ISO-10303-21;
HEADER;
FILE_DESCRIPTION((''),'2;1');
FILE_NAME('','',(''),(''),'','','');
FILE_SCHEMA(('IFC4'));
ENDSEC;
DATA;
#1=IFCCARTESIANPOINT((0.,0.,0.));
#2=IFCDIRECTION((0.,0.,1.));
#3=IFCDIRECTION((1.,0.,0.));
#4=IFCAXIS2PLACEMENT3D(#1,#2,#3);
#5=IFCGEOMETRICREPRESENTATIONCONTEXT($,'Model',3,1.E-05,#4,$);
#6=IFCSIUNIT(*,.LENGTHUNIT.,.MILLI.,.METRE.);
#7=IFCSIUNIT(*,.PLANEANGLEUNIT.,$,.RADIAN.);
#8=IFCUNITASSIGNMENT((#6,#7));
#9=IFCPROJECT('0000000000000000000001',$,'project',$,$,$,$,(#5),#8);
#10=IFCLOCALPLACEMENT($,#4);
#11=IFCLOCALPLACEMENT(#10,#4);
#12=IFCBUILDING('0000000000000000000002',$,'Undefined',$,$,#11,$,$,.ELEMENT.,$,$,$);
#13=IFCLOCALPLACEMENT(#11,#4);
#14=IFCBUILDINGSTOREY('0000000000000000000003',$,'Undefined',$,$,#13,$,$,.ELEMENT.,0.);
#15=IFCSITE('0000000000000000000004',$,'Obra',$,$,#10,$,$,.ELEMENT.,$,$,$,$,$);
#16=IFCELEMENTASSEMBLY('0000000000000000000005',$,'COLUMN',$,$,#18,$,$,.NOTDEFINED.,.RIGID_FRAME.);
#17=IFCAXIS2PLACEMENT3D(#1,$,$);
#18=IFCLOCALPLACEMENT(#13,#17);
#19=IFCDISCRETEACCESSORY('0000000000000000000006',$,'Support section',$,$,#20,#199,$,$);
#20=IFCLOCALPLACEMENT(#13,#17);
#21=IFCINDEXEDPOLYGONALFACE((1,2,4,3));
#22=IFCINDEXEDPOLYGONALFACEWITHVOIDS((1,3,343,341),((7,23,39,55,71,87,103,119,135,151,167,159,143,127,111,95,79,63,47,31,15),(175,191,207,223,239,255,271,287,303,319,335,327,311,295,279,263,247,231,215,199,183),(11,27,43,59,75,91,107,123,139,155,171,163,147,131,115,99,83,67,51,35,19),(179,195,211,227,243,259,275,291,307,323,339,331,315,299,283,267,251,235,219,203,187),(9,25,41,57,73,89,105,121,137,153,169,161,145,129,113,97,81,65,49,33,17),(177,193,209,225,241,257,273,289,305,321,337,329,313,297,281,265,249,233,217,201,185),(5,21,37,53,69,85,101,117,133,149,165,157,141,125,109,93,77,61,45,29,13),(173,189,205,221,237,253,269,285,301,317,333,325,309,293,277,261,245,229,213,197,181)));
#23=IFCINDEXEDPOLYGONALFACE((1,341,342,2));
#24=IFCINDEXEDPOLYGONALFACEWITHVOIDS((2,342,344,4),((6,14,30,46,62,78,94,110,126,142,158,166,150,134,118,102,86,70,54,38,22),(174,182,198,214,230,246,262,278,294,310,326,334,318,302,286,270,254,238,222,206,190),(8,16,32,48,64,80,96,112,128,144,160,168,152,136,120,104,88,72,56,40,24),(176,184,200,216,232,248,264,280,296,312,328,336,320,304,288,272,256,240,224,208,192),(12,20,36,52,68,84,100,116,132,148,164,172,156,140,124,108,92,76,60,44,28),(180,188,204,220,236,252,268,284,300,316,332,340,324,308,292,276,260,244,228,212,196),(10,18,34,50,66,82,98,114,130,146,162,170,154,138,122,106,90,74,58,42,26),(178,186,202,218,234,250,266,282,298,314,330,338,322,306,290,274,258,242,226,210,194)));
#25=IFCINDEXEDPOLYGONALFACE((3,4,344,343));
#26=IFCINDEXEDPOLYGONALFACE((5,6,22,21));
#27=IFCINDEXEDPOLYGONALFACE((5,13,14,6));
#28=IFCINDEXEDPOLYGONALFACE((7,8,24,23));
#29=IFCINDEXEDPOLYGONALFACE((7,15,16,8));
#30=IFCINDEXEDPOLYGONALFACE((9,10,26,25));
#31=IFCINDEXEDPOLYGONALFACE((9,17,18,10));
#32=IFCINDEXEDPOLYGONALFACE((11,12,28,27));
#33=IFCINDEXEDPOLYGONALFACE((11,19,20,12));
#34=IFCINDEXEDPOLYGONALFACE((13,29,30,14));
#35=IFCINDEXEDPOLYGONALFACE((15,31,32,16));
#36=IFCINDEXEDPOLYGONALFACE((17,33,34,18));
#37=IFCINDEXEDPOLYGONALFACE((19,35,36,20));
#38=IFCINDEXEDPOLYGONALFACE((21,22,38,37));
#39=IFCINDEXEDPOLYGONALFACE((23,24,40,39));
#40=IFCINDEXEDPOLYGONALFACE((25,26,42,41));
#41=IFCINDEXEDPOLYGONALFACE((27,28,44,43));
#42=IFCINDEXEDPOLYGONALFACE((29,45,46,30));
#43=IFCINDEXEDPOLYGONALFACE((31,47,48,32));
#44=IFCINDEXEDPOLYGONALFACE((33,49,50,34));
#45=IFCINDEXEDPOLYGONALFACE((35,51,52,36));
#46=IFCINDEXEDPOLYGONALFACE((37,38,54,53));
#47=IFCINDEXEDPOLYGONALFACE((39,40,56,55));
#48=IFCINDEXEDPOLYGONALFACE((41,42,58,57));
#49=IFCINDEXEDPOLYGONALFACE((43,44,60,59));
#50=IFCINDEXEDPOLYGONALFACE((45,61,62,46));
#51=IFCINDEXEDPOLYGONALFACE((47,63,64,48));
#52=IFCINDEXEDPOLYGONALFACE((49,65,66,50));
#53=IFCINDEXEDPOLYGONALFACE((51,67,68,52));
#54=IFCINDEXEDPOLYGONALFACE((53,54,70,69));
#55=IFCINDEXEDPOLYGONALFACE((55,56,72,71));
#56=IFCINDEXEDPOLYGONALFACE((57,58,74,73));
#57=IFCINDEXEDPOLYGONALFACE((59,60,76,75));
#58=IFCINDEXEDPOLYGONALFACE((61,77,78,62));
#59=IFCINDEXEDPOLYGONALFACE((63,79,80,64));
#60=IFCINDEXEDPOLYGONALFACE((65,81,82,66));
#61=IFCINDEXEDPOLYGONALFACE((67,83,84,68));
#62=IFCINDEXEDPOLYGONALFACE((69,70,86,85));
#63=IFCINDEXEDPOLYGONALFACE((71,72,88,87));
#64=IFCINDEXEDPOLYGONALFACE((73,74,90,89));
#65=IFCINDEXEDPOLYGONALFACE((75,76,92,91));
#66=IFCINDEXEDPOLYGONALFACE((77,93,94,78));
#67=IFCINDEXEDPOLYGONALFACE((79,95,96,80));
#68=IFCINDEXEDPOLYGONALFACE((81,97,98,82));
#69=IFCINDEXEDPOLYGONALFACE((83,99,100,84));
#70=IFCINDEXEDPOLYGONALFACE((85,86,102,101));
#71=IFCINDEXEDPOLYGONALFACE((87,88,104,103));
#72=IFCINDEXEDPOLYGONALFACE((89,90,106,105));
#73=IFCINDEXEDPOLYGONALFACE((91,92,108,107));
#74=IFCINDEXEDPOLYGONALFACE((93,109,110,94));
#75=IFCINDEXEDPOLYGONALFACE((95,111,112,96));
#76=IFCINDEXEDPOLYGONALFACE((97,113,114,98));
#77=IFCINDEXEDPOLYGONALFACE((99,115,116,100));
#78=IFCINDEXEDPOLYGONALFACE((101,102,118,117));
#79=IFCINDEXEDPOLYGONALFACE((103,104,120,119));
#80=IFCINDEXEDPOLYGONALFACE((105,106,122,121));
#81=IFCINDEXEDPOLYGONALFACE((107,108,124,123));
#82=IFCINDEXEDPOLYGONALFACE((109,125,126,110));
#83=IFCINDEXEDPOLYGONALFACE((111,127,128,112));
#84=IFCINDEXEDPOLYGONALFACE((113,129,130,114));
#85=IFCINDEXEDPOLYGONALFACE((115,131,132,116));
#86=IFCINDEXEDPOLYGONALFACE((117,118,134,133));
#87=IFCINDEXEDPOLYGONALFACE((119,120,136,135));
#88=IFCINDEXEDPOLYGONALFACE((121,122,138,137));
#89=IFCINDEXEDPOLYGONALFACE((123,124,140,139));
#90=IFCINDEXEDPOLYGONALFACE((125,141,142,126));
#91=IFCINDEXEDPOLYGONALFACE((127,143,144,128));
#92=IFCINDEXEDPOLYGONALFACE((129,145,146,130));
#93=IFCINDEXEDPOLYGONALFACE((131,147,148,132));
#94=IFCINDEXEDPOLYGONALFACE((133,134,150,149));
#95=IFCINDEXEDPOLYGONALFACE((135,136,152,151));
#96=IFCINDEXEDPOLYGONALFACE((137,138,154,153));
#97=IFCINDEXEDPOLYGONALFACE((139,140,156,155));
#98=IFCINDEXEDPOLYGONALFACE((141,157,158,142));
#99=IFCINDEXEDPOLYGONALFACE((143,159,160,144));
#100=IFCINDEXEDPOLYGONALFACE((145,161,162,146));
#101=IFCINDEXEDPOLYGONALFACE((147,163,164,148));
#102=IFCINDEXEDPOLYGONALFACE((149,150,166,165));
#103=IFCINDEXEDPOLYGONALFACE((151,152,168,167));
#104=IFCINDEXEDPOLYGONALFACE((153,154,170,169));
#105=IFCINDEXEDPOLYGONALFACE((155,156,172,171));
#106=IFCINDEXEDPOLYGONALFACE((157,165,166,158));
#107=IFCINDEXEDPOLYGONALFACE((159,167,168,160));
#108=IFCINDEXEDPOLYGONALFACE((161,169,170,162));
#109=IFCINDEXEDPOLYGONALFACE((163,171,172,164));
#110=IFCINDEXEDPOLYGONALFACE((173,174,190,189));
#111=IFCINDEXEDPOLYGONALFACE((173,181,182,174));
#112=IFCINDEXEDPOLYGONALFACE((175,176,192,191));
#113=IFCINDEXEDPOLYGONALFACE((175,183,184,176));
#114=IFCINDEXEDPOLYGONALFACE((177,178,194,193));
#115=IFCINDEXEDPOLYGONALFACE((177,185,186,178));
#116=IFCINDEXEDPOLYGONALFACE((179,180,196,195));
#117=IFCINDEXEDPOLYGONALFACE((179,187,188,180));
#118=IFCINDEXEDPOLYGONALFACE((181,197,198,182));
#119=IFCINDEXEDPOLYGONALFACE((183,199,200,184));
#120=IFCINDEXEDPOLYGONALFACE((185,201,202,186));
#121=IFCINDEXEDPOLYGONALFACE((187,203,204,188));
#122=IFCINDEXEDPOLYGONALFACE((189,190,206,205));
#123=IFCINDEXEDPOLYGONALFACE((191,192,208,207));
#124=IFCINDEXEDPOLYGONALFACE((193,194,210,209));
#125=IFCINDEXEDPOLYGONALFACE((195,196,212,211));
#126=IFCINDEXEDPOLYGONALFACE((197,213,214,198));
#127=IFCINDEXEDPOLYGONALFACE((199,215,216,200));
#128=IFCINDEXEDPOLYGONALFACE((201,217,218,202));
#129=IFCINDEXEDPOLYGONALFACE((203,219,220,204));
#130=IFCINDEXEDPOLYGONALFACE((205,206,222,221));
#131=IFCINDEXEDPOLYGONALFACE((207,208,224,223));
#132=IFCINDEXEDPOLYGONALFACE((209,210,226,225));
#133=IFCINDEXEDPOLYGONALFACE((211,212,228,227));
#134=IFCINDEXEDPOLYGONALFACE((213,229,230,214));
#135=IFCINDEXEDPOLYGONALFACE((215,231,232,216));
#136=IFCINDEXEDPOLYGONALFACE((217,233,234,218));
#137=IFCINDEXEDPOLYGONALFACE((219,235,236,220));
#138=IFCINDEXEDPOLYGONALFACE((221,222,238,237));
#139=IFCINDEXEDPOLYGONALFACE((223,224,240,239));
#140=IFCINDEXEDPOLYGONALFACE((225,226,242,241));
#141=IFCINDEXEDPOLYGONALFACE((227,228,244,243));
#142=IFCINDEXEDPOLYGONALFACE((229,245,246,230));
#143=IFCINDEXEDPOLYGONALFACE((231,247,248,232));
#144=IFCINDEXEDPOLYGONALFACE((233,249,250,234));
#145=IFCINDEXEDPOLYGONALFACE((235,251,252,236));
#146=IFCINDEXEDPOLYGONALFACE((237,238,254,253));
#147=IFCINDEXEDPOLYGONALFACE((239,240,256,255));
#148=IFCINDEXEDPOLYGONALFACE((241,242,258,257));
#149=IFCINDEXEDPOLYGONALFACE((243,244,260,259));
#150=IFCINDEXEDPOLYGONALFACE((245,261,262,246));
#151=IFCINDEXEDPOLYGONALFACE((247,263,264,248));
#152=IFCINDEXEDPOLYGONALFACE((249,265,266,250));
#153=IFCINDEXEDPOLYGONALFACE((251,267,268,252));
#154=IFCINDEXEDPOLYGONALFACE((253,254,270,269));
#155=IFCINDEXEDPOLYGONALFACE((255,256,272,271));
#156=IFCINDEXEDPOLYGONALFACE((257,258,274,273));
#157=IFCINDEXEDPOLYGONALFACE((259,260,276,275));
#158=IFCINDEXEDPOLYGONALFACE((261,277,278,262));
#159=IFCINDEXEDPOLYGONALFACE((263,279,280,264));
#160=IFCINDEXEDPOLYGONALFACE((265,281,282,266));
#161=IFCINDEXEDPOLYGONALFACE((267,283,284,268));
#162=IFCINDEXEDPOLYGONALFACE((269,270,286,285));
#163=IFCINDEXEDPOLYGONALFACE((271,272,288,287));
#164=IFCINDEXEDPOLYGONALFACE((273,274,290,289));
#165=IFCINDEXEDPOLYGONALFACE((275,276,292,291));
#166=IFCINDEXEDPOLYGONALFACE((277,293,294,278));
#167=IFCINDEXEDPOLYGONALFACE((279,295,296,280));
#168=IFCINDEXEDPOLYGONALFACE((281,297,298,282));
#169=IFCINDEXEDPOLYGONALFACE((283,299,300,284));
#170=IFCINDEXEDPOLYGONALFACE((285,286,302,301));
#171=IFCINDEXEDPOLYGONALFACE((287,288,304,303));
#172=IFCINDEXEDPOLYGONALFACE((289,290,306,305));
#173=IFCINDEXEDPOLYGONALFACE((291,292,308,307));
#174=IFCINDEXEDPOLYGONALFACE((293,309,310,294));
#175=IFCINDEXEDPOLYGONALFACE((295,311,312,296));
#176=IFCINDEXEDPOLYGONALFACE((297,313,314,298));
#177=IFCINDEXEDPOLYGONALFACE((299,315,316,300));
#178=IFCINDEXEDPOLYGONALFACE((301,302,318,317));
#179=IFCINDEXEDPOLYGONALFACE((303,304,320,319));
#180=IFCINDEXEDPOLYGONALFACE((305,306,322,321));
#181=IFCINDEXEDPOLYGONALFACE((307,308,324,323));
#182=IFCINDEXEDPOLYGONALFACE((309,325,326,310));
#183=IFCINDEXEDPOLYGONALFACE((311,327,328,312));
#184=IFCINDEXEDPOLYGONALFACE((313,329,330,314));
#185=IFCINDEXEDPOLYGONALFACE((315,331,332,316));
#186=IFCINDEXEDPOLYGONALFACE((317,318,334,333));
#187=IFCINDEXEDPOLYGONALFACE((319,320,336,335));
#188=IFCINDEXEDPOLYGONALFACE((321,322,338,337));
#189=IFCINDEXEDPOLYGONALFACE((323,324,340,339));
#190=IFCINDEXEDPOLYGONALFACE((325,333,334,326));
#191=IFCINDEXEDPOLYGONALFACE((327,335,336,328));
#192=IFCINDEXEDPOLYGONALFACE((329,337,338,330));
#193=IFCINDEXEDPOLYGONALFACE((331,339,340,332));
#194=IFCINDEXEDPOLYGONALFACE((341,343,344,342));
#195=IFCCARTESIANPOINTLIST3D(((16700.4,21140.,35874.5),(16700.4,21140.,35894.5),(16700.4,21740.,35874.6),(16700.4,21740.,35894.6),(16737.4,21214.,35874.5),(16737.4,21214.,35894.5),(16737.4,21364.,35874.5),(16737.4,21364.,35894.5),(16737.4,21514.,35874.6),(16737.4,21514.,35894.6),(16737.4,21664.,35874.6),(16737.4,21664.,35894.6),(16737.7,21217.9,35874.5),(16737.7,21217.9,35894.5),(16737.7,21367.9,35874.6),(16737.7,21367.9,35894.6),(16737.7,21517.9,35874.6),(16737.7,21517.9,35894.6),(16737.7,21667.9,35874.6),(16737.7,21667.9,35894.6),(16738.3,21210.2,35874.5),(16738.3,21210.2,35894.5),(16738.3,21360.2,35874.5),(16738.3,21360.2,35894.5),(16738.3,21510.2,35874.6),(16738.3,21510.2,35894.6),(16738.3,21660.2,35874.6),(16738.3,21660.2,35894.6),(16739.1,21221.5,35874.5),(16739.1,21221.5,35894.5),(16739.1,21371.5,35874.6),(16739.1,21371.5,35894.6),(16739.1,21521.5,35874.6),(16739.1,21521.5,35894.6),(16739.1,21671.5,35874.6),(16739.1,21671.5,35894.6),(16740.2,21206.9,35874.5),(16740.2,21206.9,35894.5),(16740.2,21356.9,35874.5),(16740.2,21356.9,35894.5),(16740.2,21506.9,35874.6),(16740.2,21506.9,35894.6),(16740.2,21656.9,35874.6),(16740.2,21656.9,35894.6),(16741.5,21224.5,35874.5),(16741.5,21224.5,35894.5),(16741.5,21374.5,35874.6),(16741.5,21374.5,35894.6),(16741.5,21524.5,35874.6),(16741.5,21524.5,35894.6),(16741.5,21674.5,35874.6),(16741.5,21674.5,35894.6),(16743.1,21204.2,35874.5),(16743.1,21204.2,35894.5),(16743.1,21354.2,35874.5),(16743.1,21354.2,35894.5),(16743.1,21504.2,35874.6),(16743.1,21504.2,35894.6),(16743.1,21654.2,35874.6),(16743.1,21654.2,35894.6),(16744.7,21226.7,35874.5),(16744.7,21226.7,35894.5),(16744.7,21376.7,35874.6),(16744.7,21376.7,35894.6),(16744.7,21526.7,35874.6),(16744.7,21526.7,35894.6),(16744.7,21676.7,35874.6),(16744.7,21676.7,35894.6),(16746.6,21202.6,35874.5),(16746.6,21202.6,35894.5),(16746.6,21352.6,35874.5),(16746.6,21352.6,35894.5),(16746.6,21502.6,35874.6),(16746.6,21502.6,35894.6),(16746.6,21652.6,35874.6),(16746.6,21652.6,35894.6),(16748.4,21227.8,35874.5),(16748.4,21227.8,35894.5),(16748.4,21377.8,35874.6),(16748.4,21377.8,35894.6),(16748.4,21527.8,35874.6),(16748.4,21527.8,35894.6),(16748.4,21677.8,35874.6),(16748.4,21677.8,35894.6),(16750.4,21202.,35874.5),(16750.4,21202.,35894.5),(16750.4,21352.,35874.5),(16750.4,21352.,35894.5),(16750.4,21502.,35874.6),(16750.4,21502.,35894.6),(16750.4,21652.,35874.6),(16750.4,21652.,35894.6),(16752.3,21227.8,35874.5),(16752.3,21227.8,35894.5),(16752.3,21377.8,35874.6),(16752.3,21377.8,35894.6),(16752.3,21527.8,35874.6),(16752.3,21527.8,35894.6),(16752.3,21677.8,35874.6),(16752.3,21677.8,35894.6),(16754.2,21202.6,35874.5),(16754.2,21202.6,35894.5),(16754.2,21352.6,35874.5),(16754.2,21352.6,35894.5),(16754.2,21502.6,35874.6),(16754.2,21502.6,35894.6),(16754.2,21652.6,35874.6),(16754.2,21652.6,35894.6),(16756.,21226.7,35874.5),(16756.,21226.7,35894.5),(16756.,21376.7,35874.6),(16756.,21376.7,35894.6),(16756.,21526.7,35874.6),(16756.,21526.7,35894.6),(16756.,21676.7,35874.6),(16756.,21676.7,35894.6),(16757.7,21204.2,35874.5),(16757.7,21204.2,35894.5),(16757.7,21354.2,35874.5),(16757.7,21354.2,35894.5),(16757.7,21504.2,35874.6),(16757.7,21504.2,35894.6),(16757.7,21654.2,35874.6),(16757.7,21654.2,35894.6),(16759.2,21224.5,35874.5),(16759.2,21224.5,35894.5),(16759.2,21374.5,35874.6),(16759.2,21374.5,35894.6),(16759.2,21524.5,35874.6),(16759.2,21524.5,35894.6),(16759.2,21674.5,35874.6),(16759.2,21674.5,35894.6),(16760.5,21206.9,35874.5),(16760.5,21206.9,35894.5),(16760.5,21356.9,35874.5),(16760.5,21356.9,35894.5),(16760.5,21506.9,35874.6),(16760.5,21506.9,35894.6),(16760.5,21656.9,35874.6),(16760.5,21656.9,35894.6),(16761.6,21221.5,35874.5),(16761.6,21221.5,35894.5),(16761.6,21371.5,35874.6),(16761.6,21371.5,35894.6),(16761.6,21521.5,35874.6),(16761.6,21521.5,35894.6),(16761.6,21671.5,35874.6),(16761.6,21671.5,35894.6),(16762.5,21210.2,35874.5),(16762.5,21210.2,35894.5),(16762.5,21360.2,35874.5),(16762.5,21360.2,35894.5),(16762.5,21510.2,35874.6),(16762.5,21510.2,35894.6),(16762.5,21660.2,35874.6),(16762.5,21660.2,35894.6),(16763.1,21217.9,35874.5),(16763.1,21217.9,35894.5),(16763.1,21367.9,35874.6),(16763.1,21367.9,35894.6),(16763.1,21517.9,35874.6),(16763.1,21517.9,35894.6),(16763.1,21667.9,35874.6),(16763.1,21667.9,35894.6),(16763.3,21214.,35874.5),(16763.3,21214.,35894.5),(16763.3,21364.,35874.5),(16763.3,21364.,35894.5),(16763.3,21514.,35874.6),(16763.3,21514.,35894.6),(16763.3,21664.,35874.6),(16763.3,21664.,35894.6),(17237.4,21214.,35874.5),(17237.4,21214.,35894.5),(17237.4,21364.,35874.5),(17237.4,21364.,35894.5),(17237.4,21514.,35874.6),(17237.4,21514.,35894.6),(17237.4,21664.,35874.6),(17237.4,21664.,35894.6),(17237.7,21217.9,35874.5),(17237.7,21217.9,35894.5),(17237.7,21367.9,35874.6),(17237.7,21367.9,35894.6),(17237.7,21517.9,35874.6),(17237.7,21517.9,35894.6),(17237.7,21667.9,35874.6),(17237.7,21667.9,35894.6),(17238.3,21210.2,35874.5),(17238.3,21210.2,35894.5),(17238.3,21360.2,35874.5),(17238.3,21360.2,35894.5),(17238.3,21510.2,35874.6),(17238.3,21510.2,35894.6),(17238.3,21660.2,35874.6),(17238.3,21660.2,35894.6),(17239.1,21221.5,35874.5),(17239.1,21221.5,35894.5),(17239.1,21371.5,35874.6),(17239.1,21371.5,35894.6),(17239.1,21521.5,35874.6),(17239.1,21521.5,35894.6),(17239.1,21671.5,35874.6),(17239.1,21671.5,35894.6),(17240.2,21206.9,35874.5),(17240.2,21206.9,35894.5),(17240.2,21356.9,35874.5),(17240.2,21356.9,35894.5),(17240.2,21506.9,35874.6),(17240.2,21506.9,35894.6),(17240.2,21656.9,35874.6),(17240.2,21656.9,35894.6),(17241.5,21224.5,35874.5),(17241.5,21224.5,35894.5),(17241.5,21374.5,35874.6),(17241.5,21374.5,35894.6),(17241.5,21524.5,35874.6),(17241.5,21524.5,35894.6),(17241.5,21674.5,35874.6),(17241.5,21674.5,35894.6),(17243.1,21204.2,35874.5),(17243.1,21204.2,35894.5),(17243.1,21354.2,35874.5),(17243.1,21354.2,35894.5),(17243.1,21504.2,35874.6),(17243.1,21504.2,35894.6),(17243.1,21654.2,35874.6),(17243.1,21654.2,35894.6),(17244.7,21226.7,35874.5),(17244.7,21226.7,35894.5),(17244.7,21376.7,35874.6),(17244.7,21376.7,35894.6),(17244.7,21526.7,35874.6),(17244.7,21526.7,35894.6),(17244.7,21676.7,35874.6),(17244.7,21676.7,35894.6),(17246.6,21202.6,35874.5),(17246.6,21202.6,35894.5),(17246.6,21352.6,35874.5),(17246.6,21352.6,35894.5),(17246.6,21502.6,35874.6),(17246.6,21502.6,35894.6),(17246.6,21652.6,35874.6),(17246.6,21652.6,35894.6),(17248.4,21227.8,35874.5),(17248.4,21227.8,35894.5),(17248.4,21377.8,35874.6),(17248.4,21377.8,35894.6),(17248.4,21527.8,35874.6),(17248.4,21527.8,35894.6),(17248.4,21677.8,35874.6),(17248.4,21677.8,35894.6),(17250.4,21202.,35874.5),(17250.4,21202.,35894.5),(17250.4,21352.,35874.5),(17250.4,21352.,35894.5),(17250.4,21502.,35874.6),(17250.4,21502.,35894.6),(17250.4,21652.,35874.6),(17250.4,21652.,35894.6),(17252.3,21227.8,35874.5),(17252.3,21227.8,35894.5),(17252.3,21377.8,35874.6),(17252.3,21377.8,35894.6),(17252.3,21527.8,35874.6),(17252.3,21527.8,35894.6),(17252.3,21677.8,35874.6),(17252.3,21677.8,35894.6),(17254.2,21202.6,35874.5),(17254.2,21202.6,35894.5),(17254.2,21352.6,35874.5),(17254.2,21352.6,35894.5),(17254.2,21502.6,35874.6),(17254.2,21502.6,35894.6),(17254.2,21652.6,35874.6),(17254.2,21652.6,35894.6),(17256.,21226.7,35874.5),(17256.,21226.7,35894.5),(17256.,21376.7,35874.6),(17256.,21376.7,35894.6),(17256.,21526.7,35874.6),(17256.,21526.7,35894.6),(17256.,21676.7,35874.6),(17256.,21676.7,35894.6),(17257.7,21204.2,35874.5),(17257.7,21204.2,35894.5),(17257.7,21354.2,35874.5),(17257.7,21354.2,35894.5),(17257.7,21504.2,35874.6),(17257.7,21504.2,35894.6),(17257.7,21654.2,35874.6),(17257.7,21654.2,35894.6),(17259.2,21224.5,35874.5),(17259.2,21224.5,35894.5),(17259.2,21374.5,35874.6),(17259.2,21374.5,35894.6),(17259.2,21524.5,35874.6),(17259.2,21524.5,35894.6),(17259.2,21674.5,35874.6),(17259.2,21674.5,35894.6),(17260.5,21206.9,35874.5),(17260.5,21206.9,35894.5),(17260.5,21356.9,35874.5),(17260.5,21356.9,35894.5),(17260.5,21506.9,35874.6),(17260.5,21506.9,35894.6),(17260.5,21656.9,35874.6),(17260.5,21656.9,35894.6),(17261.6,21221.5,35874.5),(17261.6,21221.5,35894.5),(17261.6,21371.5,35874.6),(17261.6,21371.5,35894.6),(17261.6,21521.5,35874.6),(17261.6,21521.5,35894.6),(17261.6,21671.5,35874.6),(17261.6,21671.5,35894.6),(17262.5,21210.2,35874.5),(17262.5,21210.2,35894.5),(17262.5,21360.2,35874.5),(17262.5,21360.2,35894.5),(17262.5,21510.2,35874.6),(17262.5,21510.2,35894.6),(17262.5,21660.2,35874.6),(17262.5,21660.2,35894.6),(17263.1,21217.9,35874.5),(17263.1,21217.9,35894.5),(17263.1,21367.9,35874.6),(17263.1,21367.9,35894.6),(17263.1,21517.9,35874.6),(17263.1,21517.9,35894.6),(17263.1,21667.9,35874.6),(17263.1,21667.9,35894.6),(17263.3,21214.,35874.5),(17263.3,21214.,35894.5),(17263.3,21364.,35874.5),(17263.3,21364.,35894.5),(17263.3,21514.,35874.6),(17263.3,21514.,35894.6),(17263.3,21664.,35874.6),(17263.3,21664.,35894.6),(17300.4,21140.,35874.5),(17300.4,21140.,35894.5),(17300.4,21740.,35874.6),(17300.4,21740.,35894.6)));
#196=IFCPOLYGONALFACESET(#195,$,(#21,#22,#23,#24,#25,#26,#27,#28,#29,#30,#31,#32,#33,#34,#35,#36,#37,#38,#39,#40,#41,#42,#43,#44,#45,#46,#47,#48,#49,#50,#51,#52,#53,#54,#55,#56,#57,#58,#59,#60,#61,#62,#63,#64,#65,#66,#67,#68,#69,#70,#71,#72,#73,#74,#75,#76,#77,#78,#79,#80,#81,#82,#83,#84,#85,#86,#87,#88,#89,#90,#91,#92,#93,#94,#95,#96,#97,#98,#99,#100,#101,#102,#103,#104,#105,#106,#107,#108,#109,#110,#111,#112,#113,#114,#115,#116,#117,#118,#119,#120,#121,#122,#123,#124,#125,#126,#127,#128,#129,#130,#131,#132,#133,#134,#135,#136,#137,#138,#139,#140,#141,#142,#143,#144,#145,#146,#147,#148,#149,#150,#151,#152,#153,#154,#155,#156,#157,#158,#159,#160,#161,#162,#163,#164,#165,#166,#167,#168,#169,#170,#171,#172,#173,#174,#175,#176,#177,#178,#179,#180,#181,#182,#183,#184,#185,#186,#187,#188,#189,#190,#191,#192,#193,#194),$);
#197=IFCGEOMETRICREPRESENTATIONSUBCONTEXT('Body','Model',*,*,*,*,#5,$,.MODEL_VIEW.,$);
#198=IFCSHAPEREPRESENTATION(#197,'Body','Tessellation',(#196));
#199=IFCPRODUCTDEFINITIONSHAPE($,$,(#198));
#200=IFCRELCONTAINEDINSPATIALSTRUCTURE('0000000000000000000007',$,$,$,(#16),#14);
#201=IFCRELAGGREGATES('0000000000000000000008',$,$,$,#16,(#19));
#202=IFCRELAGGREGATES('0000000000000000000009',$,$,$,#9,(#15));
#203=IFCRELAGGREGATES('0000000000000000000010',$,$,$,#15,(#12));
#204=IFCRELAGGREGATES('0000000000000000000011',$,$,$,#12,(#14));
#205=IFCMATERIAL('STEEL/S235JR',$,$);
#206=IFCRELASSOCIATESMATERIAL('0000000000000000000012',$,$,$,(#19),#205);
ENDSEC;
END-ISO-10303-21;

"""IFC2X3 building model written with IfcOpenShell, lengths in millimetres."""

from ifc_helpers import new_model, si_unit, frame, origin_with_axes, origin_2d_with_axis, place, context, subcontext, project, spatial, rectangle, circle, extrude, source, transform, mapped, material, element, aggregate, save


model = new_model("IFC2X3")

# Units and contexts
model_context = context("Model", 3, precision=1e-05, world=origin_with_axes())
body_context = subcontext(model_context, "Body", "Model", "MODEL_VIEW")
ifc_project = project(units=[si_unit("LENGTHUNIT", "METRE", prefix="MILLI"), si_unit("PLANEANGLEUNIT", "RADIAN")], contexts=[model_context])

# Site, building, storey
site_placement = place(None, origin_with_axes())
site = spatial("IfcSite", under=ifc_project, at=site_placement, Name="Obra", CompositionType="ELEMENT")
building_placement = place(site_placement, origin_with_axes())
building = spatial("IfcBuilding", under=site, at=building_placement, Name="Undefined", CompositionType="ELEMENT")
storey_placement = place(building_placement, origin_with_axes())
storey = spatial("IfcBuildingStorey", under=building, at=storey_placement, Name="Undefined", CompositionType="ELEMENT", Elevation=0.0)

# Element assembly, discrete accessory, opening
assembly_1_placement = place(storey_placement, origin_with_axes())
assembly_1 = element("IfcElementAssembly", 1, at=assembly_1_placement, inside=storey, Name="COLUMN", AssemblyPlace="NOTDEFINED", PredefinedType="RIGID_FRAME")
ifc_material_1 = material(Name="STEEL/S235JR")
discrete_accessory_1_placement = place(assembly_1_placement, frame((17000.4, 21140.0, 35884.5), z_axis=(1.0, 0.0, 0.0), x_axis=(0.0, 1.0, 0.000195)))
discrete_accessory_1 = element("IfcDiscreteAccessory", 2, at=discrete_accessory_1_placement, material=ifc_material_1, Name="Support section", context=body_context, shape_type="SweptSolid", body=[
    extrude(rectangle(XDim=20.0, YDim=600.0, at=origin_2d_with_axis()), frame((600.0, 0.0, 0.0), z_axis=(-1.0, 0.0, 0.0), x_axis=(0.0, -1.0, 0.0)), (0.0, 0.0, 1.0), 600.0),
])
shared_shape_1 = source(origin_with_axes(), body_context, "Body", "SweptSolid", [
    extrude(circle(Radius=13.0, at=origin_2d_with_axis()), frame((0.0, -0.1, 0.0), z_axis=(0.0, 1.0, 0.0), x_axis=(1.0, 0.0, 0.0)), (0.0, 0.0, 1.0), 20.2),
])
opening_1_placement = place(assembly_1_placement, frame((17000.4, 21592.5, 35894.6), z_axis=(1.0, 0.0, 0.0), x_axis=(0.0, -1.0, -0.000195)))
element("IfcOpeningElement", 3, at=opening_1_placement, cuts=discrete_accessory_1, ObjectType="Opening", context=body_context, shape_type="MappedRepresentation", body=[
    mapped(shared_shape_1, transform((-72.5, 0.0, -250.0))),
    mapped(shared_shape_1, transform((-72.5, 0.0, 250.0))),
    mapped(shared_shape_1, transform((77.5, 0.0, -250.0))),
    mapped(shared_shape_1, transform((77.5, 0.0, 250.0))),
    mapped(shared_shape_1, transform((227.5, 0.0, -250.0))),
    mapped(shared_shape_1, transform((227.5, 0.0, 250.0))),
    mapped(shared_shape_1, transform((377.5, 0.0, -250.0))),
    mapped(shared_shape_1, transform((377.5, 0.0, 250.0))),
])

aggregate(assembly_1, [discrete_accessory_1])

save(model, "model.ifc")
